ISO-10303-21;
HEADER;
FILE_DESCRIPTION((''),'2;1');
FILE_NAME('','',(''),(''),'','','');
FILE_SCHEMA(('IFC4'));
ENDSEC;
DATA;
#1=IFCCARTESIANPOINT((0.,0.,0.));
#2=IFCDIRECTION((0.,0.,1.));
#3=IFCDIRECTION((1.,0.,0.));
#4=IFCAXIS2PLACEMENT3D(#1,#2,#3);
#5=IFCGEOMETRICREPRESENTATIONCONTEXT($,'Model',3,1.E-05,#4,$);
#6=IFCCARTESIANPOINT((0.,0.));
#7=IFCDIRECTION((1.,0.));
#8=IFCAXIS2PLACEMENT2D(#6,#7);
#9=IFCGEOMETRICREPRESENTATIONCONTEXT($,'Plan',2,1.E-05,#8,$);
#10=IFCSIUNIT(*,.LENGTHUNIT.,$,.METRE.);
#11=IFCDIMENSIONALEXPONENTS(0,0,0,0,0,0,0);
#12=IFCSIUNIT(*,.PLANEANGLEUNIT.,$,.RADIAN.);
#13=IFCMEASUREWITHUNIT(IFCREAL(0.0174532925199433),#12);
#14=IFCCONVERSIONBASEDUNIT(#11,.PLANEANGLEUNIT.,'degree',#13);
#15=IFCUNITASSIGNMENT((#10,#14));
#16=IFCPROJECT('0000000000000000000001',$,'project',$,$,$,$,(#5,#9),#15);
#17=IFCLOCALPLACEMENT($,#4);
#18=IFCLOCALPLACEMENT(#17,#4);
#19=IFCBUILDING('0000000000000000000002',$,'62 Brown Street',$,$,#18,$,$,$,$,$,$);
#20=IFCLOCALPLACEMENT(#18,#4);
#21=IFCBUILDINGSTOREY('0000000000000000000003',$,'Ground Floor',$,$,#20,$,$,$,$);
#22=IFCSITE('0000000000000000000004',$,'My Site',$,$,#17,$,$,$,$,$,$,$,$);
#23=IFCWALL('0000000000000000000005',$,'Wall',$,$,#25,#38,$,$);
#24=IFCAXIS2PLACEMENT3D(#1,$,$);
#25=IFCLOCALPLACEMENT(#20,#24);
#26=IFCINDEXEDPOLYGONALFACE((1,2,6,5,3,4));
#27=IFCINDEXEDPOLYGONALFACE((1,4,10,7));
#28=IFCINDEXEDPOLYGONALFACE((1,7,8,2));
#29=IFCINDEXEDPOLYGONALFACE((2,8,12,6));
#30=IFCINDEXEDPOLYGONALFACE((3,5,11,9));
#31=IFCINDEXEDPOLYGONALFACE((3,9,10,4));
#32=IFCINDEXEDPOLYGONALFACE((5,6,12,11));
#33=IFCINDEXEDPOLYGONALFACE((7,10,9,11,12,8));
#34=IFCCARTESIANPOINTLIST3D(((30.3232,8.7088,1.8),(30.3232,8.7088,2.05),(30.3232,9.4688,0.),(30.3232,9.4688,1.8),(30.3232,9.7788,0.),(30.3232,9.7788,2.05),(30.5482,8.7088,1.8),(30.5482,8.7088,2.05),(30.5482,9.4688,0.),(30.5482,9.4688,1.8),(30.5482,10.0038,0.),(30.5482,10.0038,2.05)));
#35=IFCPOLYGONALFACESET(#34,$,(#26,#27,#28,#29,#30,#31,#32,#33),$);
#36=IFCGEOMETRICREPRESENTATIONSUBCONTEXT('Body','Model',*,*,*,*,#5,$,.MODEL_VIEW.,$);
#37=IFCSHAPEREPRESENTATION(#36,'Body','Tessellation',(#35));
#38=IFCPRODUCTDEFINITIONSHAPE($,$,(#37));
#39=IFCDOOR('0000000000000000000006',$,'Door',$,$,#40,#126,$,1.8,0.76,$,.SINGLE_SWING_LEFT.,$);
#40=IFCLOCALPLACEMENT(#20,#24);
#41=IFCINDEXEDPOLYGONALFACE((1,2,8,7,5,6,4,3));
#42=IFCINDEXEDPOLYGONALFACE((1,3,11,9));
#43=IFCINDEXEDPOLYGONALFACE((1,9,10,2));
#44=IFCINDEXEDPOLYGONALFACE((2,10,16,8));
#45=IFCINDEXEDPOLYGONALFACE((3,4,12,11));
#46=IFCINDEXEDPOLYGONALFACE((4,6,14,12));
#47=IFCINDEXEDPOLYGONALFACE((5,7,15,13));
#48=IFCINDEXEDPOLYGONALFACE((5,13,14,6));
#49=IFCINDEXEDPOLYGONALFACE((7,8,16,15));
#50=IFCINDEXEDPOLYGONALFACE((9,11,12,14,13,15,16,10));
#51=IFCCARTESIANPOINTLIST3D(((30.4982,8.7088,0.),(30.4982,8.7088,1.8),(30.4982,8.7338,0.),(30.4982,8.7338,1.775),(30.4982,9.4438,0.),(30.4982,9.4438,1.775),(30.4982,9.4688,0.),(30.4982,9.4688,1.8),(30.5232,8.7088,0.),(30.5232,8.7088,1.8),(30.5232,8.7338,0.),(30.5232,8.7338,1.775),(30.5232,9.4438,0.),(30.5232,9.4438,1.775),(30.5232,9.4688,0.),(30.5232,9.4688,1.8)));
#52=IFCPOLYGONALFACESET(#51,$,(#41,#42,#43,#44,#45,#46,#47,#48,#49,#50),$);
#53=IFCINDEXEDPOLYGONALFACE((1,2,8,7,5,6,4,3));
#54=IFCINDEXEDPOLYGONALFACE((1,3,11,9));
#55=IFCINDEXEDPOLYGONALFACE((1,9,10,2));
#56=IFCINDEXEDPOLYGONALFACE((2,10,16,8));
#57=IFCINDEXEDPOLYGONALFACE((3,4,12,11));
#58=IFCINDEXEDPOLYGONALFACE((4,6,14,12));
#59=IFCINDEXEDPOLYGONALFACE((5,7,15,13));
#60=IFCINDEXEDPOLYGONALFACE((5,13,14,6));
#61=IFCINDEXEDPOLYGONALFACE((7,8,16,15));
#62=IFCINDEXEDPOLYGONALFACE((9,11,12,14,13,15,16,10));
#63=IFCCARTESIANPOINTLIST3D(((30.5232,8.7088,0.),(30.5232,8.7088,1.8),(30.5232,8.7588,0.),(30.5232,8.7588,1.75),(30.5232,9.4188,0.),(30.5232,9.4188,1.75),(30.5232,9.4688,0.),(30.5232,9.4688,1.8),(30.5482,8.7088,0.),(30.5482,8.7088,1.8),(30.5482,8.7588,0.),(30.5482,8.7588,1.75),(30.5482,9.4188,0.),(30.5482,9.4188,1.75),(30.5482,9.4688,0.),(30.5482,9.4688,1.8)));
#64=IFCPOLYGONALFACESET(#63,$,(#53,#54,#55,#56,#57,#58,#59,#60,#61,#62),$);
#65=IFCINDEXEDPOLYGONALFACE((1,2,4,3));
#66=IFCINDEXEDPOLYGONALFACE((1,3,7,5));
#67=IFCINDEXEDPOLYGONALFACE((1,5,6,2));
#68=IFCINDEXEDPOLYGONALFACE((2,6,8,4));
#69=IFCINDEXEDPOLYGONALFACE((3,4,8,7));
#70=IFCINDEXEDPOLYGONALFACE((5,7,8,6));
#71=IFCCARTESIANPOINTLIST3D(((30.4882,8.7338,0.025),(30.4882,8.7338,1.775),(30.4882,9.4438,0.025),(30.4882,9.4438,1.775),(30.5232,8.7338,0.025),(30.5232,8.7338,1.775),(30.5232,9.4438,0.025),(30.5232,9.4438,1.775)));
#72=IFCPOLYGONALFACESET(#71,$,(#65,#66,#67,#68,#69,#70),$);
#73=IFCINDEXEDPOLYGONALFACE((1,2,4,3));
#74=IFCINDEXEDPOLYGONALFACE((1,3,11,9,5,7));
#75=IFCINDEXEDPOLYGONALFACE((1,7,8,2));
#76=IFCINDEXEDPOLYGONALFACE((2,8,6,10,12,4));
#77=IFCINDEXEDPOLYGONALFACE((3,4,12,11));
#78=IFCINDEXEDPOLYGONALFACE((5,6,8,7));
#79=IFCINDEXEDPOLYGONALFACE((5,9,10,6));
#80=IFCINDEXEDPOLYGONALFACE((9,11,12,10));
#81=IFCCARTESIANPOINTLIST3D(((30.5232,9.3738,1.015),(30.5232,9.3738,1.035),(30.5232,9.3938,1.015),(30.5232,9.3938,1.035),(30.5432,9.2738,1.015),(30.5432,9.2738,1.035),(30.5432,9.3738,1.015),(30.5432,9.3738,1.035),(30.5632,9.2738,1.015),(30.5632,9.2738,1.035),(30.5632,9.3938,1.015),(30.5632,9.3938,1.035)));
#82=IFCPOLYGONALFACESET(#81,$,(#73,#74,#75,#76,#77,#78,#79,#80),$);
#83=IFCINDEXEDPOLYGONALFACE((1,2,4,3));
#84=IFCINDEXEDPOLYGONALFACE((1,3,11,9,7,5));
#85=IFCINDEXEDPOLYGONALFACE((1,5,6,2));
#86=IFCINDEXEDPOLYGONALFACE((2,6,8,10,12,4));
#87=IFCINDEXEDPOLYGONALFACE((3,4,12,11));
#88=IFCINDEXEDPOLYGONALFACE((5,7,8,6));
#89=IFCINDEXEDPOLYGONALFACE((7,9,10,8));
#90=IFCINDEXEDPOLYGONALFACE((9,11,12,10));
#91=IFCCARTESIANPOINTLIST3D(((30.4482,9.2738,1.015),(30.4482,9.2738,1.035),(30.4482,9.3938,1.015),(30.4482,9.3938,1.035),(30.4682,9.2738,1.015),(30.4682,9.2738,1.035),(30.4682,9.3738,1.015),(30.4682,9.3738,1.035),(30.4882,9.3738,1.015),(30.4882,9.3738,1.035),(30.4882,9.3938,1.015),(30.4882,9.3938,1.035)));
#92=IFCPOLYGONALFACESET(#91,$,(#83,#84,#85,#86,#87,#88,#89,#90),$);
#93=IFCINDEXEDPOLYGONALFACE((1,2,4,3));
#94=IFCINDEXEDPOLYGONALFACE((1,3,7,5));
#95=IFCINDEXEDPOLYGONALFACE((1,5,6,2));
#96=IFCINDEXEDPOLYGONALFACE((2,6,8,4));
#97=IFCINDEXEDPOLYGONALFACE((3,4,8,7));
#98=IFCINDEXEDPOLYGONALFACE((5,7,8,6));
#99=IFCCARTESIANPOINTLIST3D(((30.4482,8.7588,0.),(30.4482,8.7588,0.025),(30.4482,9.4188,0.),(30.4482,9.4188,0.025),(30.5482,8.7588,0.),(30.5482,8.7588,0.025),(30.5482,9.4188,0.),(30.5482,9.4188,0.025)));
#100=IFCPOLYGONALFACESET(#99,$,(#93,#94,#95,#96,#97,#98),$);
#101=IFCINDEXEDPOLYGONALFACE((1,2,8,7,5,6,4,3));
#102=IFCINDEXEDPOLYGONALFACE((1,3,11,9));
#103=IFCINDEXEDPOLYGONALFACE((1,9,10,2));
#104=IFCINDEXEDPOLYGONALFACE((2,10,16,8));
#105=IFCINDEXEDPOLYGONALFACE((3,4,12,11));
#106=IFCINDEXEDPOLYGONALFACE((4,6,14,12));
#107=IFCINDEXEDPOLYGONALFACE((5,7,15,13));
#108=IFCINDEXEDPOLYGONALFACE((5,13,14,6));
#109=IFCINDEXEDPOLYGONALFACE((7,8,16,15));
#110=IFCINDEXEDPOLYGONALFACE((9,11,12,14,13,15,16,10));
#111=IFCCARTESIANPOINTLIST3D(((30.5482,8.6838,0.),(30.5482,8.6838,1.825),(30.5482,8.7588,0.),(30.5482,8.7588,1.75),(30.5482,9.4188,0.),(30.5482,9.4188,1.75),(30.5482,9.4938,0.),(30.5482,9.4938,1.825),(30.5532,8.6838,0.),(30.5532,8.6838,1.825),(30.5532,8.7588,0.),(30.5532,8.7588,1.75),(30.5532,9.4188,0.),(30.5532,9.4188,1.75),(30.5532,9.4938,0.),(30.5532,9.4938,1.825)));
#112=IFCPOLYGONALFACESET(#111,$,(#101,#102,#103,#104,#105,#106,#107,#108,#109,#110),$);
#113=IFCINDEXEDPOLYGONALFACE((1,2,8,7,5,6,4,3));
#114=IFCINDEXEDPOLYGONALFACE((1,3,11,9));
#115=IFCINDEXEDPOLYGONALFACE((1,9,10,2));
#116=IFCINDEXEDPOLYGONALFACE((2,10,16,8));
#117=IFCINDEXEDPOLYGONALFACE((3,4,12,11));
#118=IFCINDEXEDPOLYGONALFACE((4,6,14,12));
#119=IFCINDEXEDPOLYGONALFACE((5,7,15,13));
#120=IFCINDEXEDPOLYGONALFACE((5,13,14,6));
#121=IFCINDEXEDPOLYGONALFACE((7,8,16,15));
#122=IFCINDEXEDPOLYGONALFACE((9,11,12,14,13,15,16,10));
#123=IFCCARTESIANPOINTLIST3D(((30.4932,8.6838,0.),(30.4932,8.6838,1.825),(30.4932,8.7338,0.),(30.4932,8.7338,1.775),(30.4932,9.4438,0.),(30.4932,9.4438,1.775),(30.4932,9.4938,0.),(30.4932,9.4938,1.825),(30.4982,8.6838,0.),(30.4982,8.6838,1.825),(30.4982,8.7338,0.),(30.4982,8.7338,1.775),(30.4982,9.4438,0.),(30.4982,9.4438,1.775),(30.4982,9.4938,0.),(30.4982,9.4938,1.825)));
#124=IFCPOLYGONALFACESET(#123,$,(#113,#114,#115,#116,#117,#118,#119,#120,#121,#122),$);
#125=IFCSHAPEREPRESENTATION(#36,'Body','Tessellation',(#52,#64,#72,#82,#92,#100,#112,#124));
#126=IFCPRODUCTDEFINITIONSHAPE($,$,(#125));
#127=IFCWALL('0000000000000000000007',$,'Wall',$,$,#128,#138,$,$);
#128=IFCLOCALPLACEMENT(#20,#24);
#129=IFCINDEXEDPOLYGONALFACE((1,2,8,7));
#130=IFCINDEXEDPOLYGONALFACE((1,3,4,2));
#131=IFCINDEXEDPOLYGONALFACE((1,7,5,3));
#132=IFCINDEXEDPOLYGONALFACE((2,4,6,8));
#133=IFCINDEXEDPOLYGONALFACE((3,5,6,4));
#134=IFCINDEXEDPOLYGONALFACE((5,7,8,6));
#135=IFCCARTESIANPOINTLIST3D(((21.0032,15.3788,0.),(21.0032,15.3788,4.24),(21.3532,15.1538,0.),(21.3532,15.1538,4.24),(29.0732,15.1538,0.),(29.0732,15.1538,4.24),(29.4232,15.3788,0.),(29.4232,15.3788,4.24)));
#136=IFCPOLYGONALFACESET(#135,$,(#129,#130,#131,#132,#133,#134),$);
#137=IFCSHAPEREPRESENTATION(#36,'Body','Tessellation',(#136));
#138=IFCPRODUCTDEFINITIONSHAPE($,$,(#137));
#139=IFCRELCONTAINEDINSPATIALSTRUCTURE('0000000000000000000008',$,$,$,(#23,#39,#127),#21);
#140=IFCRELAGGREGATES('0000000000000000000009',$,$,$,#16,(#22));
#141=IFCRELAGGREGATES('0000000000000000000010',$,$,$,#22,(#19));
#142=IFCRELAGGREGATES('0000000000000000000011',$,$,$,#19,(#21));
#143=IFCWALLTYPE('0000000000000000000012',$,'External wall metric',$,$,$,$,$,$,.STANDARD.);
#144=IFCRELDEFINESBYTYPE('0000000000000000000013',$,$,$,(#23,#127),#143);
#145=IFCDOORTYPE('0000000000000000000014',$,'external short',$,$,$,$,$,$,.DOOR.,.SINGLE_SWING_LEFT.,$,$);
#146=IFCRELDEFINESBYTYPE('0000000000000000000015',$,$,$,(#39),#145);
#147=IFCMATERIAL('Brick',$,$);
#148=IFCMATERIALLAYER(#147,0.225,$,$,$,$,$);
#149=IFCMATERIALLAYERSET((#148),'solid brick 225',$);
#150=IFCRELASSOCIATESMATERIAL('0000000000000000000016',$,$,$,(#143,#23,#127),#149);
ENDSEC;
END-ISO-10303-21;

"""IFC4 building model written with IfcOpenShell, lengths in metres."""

from ifc_helpers import new_model, entity, si_unit, converted_unit, frame, origin_with_axes, origin_2d_with_axis, place, context, subcontext, project, spatial, line, indexed_curve, outline, extrude, clip, halfspace, shape, source, transform, mapped, material, layer, layer_set, layer_usage, type_object, type_shapes, element, fill, save


model = new_model("IFC4")

# Units and contexts
model_context = context("Model", 3, precision=1e-05, world=origin_with_axes())
plan_context = context("Plan", 2, precision=1e-05, world=origin_2d_with_axis())
body_context_1 = subcontext(model_context, "Body", "Model", "MODEL_VIEW")
body_context_2 = subcontext(plan_context, "Body", "Plan", "PLAN_VIEW")
ifc_project = project(units=[si_unit("LENGTHUNIT", "METRE"), converted_unit("PLANEANGLEUNIT", "degree", entity("IfcReal", 0.0174532925199433), si_unit("PLANEANGLEUNIT", "RADIAN"), dimensions=[0, 0, 0, 0, 0, 0, 0])], contexts=[model_context, plan_context])

# Site, building, storey
site_placement = place(None, origin_with_axes())
site = spatial("IfcSite", under=ifc_project, at=site_placement, Name="My Site")
building_placement = place(site_placement, origin_with_axes())
building = spatial("IfcBuilding", under=site, at=building_placement, Name="62 Brown Street")
storey_placement = place(building_placement, origin_with_axes())
storey = spatial("IfcBuildingStorey", under=building, at=storey_placement, Name="Ground Floor")

# Shared definitions
ifc_material_1 = material(Name="Brick")

# Shared definitions
ifc_layer_1 = layer(ifc_material_1, 0.225)
ifc_layer_set_1 = layer_set([ifc_layer_1], Name="solid brick 225")
wall_type_1 = type_object("IfcWallType", Name="External wall metric", PredefinedType="STANDARD", material=ifc_layer_set_1)

# Wall, opening, door
ifc_layer_usage_1 = layer_usage(ifc_layer_set_1, "AXIS2", "POSITIVE", 0.0)
wall_1_placement = place(storey_placement, frame((30.5482, 8.7088, 0.0), z_axis=(0.0, 0.0, 1.0), x_axis=(0.0, 1.0, 0.0)))
wall_1 = element("IfcWall", 1, at=wall_1_placement, inside=storey, type_object=wall_type_1, material=ifc_layer_usage_1, Name="Wall", context=body_context_1, shape_type="Clipping", body=[
    clip(extrude(outline(indexed_curve([(0.0, 0.0), (0.0, 0.225), (1.295, 0.225), (1.295, 0.0), (0.0, 0.0)], self_intersect=False)), origin_with_axes(), (0.0, 0.0, 1.0), 2.05), halfspace(frame((1.295, 0.0, 0.0), z_axis=(0.450001, 0.450001, 0.0), x_axis=(-0.225, 0.225, 0.0)), False)),
])
shared_shape_1 = source(origin_with_axes(), body_context_1, "Body", "SweptSolid", [
    extrude(outline(indexed_curve([(0.0, 0.0), (0.76, 0.0), (0.76, 1.8), (0.0, 1.8)], segments=[line(1, 2, 3, 4, 1)])), frame((0.0, -0.1, 0.0), z_axis=(0.0, -1.0, 0.0), x_axis=(1.0, 0.0, 0.0)), (0.0, 0.0, -1.0), 0.425),
])
opening_1_placement = place(wall_1_placement, frame((0.0, 0.0, 0.0), z_axis=(0.0, 0.0, 1.0), x_axis=(1.0, 0.0, 0.0)))
opening_1 = element("IfcOpeningElement", 2, at=opening_1_placement, cuts=wall_1, PredefinedType="OPENING", context=body_context_1, shape_type="MappedRepresentation", body=[
    mapped(shared_shape_1, transform((0.0, 0.0, 0.0), x_axis=(1.0, 0.0, 0.0), y_axis=(0.0, 1.0, 0.0), z_axis=(0.0, 0.0, 1.0), scale=1.0)),
])
door_type_1 = type_object("IfcDoorType", Name="external short", OperationType="SINGLE_SWING_LEFT", PredefinedType="DOOR")
shared_shape_2 = source(origin_with_axes(), body_context_1, "Body", "SweptSolid", [
    extrude(outline(indexed_curve([(0.0, 0.0), (0.0, 1.8), (0.76, 1.8), (0.76, 0.0), (0.735, 0.0), (0.735, 1.775), (0.025, 1.775), (0.025, 0.0)], segments=[line(1, 2, 3, 4, 5, 6, 7, 8, 1)])), frame((0.0, 0.025, 0.0), z_axis=(0.0, -1.0, 0.0), x_axis=(1.0, 0.0, 0.0)), (0.0, 0.0, -1.0), 0.025),
    extrude(outline(indexed_curve([(0.0, 0.0), (0.0, 1.8), (0.76, 1.8), (0.76, 0.0), (0.71, 0.0), (0.71, 1.75), (0.05, 1.75), (0.05, 0.0)], segments=[line(1, 2, 3, 4, 5, 6, 7, 8, 1)])), frame((0.0, 0.0, 0.0), z_axis=(0.0, -1.0, 0.0), x_axis=(1.0, 0.0, 0.0)), (0.0, 0.0, -1.0), 0.025),
    extrude(outline(indexed_curve([(0.0, 0.0), (0.71, 0.0), (0.71, 0.035), (0.0, 0.035)], segments=[line(1, 2, 3, 4, 1)])), frame((0.025, 0.025, 0.025), z_axis=(0.0, 0.0, 1.0), x_axis=(1.0, 0.0, 0.0)), (0.0, 0.0, 1.0), 1.75),
    extrude(outline(indexed_curve([(0.0, 0.0), (0.0, -0.04), (-0.12, -0.04), (-0.12, -0.02), (-0.02, -0.02), (-0.02, 0.0)], segments=[line(1, 2, 3, 4, 5, 6, 1)])), frame((0.685, 0.025, 1.015), z_axis=(0.0, 0.0, 1.0), x_axis=(1.0, 0.0, 0.0)), (0.0, 0.0, 1.0), 0.02),
    extrude(outline(indexed_curve([(0.0, 0.0), (0.0, 0.04), (-0.12, 0.04), (-0.12, 0.02), (-0.02, 0.02), (-0.02, 0.0)], segments=[line(1, 2, 3, 4, 5, 6, 1)])), frame((0.685, 0.06, 1.015), z_axis=(0.0, 0.0, 1.0), x_axis=(1.0, 0.0, 0.0)), (0.0, 0.0, 1.0), 0.02),
    extrude(outline(indexed_curve([(0.0, 0.0), (0.66, 0.0), (0.66, 0.1), (0.0, 0.1)], segments=[line(1, 2, 3, 4, 1)])), frame((0.05, 0.0, 0.0), z_axis=(0.0, 0.0, 1.0), x_axis=(1.0, 0.0, 0.0)), (0.0, 0.0, 1.0), 0.025),
    extrude(outline(indexed_curve([(0.0, 0.0), (0.0, 1.825), (0.81, 1.825), (0.81, 0.0), (0.735, 0.0), (0.735, 1.75), (0.075, 1.75), (0.075, 0.0)], segments=[line(1, 2, 3, 4, 5, 6, 7, 8, 1)])), frame((-0.025, -0.005, 0.0), z_axis=(0.0, -1.0, 0.0), x_axis=(1.0, 0.0, 0.0)), (0.0, 0.0, -1.0), 0.005),
    extrude(outline(indexed_curve([(0.0, 0.0), (0.0, 1.825), (0.81, 1.825), (0.81, 0.0), (0.76, 0.0), (0.76, 1.775), (0.05, 1.775), (0.05, 0.0)], segments=[line(1, 2, 3, 4, 5, 6, 7, 8, 1)])), frame((-0.025, 0.05, 0.0), z_axis=(0.0, -1.0, 0.0), x_axis=(1.0, 0.0, 0.0)), (0.0, 0.0, -1.0), 0.005),
])
shared_shape_3 = source(origin_with_axes(), body_context_2, "Body", "Curve2D", [
    entity("IfcIndexedPolyCurve", entity("IfcCartesianPointList2D", [[0.0, 0.0], [0.0, 0.05], [0.025, 0.05], [0.025, 0.025], [0.05, 0.025], [0.05, 0.0]]), [entity("IfcLineIndex", [1, 2, 3, 4, 5, 6, 1])]),
    entity("IfcIndexedPolyCurve", entity("IfcCartesianPointList2D", [[0.76, 0.0], [0.76, 0.05], [0.735, 0.05], [0.735, 0.025], [0.71, 0.025], [0.71, 0.0]]), [entity("IfcLineIndex", [1, 2, 3, 4, 5, 6, 1])]),
    entity("IfcTrimmedCurve", entity("IfcEllipse", entity("IfcAxis2Placement2D", entity("IfcCartesianPoint", [0.06, 0.05]), entity("IfcDirection", [1.0, 0.0])), 0.675, 0.71), [entity("IfcCartesianPoint", [0.735, 0.05])], [entity("IfcCartesianPoint", [0.06, 0.76])], True, "CARTESIAN"),
    entity("IfcIndexedPolyCurve", entity("IfcCartesianPointList2D", [[0.025, 0.05], [0.06, 0.05], [0.06, 0.76], [0.025, 0.76]]), [entity("IfcLineIndex", [1, 2, 3, 4, 1])]),
])
type_shapes(door_type_1, [shared_shape_2, shared_shape_3])
door_1_placement = place(opening_1_placement, frame((0.0, 0.0, 0.0), z_axis=(0.0, 0.0, 1.0), x_axis=(1.0, 0.0, 0.0)))
door_1 = element("IfcDoor", 3, at=door_1_placement, inside=storey, type_object=door_type_1, Name="Door", OperationType="SINGLE_SWING_LEFT", OverallHeight=1.8, OverallWidth=0.76, shapes=[
    shape(body_context_1, "Body", "MappedRepresentation", [mapped(shared_shape_2, transform((0.0, 0.0, 0.0), x_axis=(1.0, 0.0, 0.0), y_axis=(0.0, 1.0, 0.0), z_axis=(0.0, 0.0, 1.0), scale=1.0))]),
    shape(body_context_2, "Body", "MappedRepresentation", [mapped(shared_shape_3, transform((0.0, 0.0, 0.0), x_axis=(1.0, 0.0, 0.0), y_axis=(0.0, 1.0, 0.0), z_axis=(0.0, 0.0, 1.0), scale=1.0))]),
])
fill(opening_1, door_1)

# Wall
ifc_layer_usage_2 = layer_usage(ifc_layer_set_1, "AXIS2", "POSITIVE", 0.0)
wall_2_placement = place(storey_placement, frame((29.4232, 15.3788, 0.0), z_axis=(0.0, 0.0, 1.0), x_axis=(-1.0, 0.0, 0.0)))
element("IfcWall", 4, at=wall_2_placement, inside=storey, type_object=wall_type_1, material=ifc_layer_usage_2, Name="Wall", context=body_context_1, shape_type="Clipping", body=[
    clip(clip(extrude(outline(indexed_curve([(0.0, 0.0), (0.0, 0.225), (8.42, 0.225), (8.42, 0.0), (0.0, 0.0)], self_intersect=False)), origin_with_axes(), (0.0, 0.0, 1.0), 4.24), halfspace(frame((8.42, 0.0, 0.0), z_axis=(0.540756, 0.841179, 0.0), x_axis=(-0.841179, 0.540756, 0.0)), False)), halfspace(frame((0.0, 0.0, 0.0), z_axis=(-0.540758, 0.841178, 0.0), x_axis=(0.841178, 0.540758, 0.0)), False)),
])

save(model, "model.ifc")
